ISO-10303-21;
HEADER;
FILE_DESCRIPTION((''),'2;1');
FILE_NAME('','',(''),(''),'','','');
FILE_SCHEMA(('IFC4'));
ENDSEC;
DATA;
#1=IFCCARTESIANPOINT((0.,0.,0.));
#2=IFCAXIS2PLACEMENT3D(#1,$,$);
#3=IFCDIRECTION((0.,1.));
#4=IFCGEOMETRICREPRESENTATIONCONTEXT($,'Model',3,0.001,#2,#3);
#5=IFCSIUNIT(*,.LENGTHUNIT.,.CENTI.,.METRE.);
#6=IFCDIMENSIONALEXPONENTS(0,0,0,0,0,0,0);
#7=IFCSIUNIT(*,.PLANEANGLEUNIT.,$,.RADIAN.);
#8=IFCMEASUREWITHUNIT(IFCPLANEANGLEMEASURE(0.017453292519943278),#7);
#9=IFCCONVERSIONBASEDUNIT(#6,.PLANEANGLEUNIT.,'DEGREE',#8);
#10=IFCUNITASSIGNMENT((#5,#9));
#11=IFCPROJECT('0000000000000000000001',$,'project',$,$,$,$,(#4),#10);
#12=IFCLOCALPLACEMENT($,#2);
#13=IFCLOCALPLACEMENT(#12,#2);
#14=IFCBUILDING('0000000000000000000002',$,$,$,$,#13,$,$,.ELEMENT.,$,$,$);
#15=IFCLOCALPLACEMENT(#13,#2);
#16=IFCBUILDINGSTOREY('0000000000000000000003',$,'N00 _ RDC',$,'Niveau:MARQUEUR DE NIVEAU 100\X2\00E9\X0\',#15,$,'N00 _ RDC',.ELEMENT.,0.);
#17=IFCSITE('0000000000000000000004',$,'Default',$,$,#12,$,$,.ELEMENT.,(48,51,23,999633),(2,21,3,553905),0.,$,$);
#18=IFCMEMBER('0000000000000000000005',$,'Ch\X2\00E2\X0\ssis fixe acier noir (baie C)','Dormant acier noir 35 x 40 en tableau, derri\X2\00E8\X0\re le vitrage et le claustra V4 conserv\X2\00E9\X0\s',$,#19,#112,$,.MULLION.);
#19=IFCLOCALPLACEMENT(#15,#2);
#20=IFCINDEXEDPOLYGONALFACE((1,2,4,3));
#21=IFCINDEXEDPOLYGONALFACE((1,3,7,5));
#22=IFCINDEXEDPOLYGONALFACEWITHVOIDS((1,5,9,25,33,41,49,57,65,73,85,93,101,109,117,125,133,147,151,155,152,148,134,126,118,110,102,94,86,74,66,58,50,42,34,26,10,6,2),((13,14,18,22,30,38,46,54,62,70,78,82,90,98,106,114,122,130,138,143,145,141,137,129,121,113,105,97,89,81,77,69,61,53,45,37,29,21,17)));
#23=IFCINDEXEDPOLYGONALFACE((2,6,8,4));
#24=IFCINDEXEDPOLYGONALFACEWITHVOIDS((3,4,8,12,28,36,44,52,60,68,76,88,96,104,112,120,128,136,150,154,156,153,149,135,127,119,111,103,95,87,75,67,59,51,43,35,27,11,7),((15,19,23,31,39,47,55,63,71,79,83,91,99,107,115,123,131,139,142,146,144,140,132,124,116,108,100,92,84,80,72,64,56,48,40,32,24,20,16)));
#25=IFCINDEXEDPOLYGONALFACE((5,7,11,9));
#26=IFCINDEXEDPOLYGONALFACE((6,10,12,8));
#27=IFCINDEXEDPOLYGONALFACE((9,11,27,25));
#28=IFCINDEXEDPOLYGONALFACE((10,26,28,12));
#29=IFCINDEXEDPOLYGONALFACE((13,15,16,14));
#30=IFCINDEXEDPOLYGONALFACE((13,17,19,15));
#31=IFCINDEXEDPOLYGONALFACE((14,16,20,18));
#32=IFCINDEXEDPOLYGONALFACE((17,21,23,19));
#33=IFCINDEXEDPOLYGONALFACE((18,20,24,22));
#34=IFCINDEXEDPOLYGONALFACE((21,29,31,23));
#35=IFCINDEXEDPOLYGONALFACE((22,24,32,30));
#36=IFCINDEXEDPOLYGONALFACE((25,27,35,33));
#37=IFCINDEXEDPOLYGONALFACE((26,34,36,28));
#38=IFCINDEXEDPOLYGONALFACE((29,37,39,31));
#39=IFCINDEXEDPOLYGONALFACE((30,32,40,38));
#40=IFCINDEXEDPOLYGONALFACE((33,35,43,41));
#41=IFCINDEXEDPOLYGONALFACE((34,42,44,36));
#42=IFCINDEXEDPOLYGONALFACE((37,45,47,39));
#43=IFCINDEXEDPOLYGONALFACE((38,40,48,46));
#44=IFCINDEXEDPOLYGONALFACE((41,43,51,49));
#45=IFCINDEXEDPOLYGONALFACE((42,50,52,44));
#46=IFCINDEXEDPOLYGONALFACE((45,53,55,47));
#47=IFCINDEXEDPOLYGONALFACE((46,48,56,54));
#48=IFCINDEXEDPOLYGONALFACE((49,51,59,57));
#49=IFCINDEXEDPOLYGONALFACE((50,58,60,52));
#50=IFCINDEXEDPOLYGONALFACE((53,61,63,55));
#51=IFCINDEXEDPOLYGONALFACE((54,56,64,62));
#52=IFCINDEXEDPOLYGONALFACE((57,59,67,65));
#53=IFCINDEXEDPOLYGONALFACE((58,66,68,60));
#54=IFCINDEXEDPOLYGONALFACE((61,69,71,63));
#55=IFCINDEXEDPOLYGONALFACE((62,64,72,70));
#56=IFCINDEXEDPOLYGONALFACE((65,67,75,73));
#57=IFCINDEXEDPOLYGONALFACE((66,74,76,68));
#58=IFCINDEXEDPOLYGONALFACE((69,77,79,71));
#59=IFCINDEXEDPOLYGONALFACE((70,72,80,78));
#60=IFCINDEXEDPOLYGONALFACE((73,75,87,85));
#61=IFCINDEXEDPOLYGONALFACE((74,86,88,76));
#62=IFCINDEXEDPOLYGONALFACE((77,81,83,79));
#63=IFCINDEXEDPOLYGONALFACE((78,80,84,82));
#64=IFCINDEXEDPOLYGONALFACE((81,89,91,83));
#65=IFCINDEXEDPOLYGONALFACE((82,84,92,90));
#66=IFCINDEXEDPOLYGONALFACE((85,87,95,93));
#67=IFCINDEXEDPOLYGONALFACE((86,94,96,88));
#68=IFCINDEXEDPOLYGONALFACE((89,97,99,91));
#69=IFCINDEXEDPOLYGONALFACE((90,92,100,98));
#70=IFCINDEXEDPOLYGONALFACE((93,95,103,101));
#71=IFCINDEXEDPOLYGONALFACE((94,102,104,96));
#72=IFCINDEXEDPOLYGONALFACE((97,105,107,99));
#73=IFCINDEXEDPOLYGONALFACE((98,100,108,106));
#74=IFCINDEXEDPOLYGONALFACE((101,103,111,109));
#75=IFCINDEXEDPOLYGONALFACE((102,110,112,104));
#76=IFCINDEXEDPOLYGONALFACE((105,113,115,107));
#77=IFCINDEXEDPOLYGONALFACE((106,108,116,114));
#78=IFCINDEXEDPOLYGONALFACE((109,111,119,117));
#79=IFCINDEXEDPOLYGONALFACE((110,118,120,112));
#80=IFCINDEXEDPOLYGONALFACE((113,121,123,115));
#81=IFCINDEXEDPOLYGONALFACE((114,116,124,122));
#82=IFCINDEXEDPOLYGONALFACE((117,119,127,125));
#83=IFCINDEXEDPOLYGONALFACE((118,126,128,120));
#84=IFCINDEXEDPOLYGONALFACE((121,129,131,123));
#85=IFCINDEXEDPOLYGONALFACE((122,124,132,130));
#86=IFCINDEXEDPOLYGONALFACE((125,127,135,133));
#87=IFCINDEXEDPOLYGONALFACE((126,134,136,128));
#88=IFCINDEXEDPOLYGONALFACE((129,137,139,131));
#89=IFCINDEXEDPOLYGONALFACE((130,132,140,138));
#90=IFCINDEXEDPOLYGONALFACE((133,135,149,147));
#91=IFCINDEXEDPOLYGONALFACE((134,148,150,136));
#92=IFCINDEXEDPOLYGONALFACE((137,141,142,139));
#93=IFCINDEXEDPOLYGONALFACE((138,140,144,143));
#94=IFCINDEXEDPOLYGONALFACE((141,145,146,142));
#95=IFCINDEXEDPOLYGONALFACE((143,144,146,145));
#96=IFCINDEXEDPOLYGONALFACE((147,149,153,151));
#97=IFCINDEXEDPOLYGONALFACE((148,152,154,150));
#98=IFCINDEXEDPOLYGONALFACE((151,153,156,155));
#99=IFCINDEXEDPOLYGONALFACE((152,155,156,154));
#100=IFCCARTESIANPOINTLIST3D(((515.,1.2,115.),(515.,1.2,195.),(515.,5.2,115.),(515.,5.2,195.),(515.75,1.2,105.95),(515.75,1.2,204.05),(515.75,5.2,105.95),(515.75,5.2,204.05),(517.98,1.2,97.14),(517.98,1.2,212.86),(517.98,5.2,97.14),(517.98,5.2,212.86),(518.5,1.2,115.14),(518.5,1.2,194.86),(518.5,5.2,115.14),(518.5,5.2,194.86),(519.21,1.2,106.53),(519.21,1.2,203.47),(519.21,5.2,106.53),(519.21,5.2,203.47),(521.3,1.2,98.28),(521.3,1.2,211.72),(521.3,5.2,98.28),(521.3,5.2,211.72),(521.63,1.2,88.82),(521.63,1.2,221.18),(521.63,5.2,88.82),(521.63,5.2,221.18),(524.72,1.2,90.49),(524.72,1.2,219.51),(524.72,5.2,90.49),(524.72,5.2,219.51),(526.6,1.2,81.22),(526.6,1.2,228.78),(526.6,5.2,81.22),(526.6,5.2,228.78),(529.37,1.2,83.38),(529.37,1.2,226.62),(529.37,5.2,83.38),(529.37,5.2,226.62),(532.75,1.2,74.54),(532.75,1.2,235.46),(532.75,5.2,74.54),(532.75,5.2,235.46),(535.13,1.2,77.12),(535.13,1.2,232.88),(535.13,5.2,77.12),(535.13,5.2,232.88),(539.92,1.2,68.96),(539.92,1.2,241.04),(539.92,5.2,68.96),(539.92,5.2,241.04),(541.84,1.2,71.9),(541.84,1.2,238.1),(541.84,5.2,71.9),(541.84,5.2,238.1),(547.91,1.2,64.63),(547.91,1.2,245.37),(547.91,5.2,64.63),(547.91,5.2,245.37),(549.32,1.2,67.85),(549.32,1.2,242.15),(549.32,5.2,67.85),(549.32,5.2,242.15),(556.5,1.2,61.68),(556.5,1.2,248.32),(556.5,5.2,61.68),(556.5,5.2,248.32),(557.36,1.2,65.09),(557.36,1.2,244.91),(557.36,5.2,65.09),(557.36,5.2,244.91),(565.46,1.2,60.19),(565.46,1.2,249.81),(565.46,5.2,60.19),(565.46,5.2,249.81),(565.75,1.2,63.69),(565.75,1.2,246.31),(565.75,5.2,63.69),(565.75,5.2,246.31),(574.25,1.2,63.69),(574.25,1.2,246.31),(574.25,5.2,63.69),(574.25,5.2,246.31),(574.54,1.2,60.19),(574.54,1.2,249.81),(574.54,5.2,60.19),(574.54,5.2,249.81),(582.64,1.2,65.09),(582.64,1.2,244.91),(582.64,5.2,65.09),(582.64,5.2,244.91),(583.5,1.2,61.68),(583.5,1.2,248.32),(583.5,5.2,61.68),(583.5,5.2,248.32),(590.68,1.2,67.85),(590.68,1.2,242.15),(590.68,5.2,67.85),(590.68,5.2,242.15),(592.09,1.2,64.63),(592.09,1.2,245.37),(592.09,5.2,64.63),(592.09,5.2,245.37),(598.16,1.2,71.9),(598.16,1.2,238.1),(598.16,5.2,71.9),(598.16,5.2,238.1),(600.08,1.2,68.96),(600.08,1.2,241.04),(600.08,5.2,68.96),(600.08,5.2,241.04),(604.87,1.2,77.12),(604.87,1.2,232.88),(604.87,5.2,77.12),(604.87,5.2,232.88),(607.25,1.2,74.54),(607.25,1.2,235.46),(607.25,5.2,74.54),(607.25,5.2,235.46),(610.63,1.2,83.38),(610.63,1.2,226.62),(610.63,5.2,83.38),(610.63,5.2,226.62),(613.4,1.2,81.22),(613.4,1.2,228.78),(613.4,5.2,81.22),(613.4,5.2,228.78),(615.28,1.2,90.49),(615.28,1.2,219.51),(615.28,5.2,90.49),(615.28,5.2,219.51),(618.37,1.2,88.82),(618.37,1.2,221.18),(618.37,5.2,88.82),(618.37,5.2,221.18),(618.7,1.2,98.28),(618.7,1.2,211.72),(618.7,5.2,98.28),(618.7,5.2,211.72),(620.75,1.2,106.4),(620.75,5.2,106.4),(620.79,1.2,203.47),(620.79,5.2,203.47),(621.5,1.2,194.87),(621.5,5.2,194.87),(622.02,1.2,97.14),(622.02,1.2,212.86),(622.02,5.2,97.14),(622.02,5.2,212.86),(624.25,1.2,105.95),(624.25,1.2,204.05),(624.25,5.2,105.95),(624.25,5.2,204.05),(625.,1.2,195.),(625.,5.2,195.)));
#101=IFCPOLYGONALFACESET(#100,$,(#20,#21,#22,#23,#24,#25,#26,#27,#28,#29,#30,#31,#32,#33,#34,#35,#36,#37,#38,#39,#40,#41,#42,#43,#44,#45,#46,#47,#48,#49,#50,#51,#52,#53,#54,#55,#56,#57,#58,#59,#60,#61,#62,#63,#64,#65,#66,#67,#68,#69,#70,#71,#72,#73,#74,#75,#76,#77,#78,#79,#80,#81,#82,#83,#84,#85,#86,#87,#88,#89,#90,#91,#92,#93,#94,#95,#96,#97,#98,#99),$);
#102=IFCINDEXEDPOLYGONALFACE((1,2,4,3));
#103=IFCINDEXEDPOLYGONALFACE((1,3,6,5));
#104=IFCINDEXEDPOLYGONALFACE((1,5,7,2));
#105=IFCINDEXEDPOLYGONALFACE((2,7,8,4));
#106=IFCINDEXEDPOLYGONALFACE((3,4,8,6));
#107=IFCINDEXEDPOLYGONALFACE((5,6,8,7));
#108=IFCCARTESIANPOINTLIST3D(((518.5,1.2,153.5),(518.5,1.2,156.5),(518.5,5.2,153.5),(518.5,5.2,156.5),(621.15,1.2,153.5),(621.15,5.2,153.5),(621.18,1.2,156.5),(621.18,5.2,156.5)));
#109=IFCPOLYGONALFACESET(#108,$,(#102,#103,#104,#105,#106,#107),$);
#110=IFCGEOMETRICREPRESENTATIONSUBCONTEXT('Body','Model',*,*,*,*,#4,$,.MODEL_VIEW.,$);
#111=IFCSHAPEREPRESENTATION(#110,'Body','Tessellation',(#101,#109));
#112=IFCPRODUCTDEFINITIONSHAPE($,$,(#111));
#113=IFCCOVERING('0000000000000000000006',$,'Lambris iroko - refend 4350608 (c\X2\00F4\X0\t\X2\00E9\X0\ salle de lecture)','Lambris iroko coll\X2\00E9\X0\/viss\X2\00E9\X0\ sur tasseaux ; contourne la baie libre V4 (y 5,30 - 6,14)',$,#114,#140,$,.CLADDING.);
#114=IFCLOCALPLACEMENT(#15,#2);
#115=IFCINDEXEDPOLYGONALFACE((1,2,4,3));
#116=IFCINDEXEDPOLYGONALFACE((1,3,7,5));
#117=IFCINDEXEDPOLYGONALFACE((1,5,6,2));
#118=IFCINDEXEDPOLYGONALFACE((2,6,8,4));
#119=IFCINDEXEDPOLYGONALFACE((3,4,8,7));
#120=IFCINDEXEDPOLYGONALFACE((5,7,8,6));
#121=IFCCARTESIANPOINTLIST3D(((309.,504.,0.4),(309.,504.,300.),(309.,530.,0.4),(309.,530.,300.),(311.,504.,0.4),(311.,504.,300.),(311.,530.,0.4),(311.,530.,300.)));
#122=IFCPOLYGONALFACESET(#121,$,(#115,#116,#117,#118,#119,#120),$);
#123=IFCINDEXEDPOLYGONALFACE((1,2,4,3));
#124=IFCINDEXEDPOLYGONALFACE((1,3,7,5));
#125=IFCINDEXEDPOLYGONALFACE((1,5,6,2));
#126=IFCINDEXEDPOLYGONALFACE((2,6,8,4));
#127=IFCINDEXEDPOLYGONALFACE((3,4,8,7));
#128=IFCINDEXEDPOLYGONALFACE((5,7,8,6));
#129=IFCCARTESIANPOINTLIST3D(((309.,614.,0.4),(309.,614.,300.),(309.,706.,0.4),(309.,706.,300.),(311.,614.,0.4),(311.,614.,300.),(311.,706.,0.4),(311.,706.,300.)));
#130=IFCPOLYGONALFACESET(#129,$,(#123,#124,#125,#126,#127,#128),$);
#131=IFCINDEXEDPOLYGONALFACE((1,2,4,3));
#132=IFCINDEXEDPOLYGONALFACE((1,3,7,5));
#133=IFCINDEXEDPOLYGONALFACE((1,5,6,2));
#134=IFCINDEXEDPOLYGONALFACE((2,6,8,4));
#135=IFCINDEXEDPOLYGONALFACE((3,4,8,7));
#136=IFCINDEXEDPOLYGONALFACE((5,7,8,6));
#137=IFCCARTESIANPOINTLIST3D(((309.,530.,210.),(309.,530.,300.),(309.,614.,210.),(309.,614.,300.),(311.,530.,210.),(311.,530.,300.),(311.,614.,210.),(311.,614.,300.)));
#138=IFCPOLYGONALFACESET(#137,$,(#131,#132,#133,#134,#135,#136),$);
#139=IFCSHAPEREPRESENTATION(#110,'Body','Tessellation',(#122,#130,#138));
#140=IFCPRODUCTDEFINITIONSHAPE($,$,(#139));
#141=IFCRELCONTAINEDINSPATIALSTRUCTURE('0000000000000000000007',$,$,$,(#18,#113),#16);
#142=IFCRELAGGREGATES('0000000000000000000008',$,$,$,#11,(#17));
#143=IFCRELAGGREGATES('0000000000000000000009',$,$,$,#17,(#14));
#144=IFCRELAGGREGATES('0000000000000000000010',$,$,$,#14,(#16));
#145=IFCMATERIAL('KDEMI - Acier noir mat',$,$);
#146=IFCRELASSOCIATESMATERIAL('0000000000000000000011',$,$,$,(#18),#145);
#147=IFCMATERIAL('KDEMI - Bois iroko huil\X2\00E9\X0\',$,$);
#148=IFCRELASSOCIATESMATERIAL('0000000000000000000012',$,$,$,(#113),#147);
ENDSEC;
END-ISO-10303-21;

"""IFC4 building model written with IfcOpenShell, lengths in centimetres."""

from ifc_helpers import new_model, entity, si_unit, converted_unit, direction, frame, frame_2d, origin, origin_with_axes, place, context, subcontext, project, spatial, polyline, rectangle, outline, extrude, material, element, save


model = new_model("IFC4")

# Units and contexts
model_context = context("Model", 3, precision=0.001, world=origin(), true_north=direction((0.0, 1.0)))
body_context = subcontext(model_context, "Body", "Model", "MODEL_VIEW")
ifc_project = project(units=[si_unit("LENGTHUNIT", "METRE", prefix="CENTI"), converted_unit("PLANEANGLEUNIT", "DEGREE", entity("IfcPlaneAngleMeasure", 0.017453292519943278), si_unit("PLANEANGLEUNIT", "RADIAN"), dimensions=[0, 0, 0, 0, 0, 0, 0])], contexts=[model_context])

# Site, building, storey
site_placement = place(None, origin())
site = spatial("IfcSite", under=ifc_project, at=site_placement, Name="Default", CompositionType="ELEMENT", RefLatitude=(48, 51, 23, 999633), RefLongitude=(2, 21, 3, 553905), RefElevation=0.0)
building_placement = place(site_placement, origin())
building = spatial("IfcBuilding", under=site, at=building_placement, CompositionType="ELEMENT")
storey_placement = place(building_placement, origin())
storey = spatial("IfcBuildingStorey", under=building, at=storey_placement, Name="N00 _ RDC", ObjectType="Niveau:MARQUEUR DE NIVEAU 100é", LongName="N00 _ RDC", CompositionType="ELEMENT", Elevation=0.0)

# Member
ifc_material_1 = material(Name="KDEMI - Acier noir mat")
member_1_placement = place(storey_placement, origin_with_axes())
element("IfcMember", 1, at=member_1_placement, inside=storey, material=ifc_material_1, Name="Châssis fixe acier noir (baie C)", Description="Dormant acier noir 35 x 40 en tableau, derrière le vitrage et le claustra V4 conservés", PredefinedType="MULLION", context=body_context, shape_type="SweptSolid", body=[
    extrude(outline(polyline([(624.25, 105.95), (622.02, 97.14), (618.37, 88.82), (613.4, 81.22), (607.25, 74.54), (600.08, 68.96), (592.09, 64.63), (583.5, 61.68), (574.54, 60.19), (565.46, 60.19), (556.5, 61.68), (547.91, 64.63), (539.92, 68.96), (532.75, 74.54), (526.6, 81.22), (521.63, 88.82), (517.98, 97.14), (515.75, 105.95), (515.0, 115.0), (515.0, 195.0), (515.75, 204.05), (517.98, 212.86), (521.63, 221.18), (526.6, 228.78), (532.75, 235.46), (539.92, 241.04), (547.91, 245.37), (556.5, 248.32), (565.46, 249.81), (574.54, 249.81), (583.5, 248.32), (592.09, 245.37), (600.08, 241.04), (607.25, 235.46), (613.4, 228.78), (618.37, 221.18), (622.02, 212.86), (624.25, 204.05), (625.0, 195.0), (624.25, 105.95)]), holes=[polyline([(620.79, 203.47), (618.7, 211.72), (615.28, 219.51), (610.63, 226.62), (604.87, 232.88), (598.16, 238.1), (590.68, 242.15), (582.64, 244.91), (574.25, 246.31), (565.75, 246.31), (557.36, 244.91), (549.32, 242.15), (541.84, 238.1), (535.13, 232.88), (529.37, 226.62), (524.72, 219.51), (521.3, 211.72), (519.21, 203.47), (518.5, 194.86), (518.5, 115.14), (519.21, 106.53), (521.3, 98.28), (524.72, 90.49), (529.37, 83.38), (535.13, 77.12), (541.84, 71.9), (549.32, 67.85), (557.36, 65.09), (565.75, 63.69), (574.25, 63.69), (582.64, 65.09), (590.68, 67.85), (598.16, 71.9), (604.87, 77.12), (610.63, 83.38), (615.28, 90.49), (618.7, 98.28), (620.75, 106.4), (621.5, 194.87), (620.79, 203.47)])]), frame((0.0, 5.2, 0.0), z_axis=(0.0, -1.0, 0.0), x_axis=(1.0, 0.0, 0.0)), (0.0, 0.0, 1.0), 4.0),
    extrude(outline(polyline([(621.18, 156.5), (621.15, 153.5), (518.5, 153.5), (518.5, 156.5), (621.18, 156.5)])), frame((0.0, 5.2, 0.0), z_axis=(0.0, -1.0, 0.0), x_axis=(1.0, 0.0, 0.0)), (0.0, 0.0, 1.0), 4.0),
])

# Covering
ifc_material_2 = material(Name="KDEMI - Bois iroko huilé")
covering_placement = place(storey_placement, origin_with_axes())
element("IfcCovering", 2, at=covering_placement, inside=storey, material=ifc_material_2, Name="Lambris iroko - refend 4350608 (côté salle de lecture)", Description="Lambris iroko collé/vissé sur tasseaux ; contourne la baie libre V4 (y 5,30 - 6,14)", PredefinedType="CLADDING", context=body_context, shape_type="SweptSolid", body=[
    extrude(rectangle(XDim=2.0, YDim=26.0, at=frame_2d((310.0, 517.0))), frame((0.0, 0.0, 0.4)), (0.0, 0.0, 1.0), 299.6),
    extrude(rectangle(XDim=2.0, YDim=92.0, at=frame_2d((310.0, 660.0))), frame((0.0, 0.0, 0.4)), (0.0, 0.0, 1.0), 299.6),
    extrude(rectangle(XDim=2.0, YDim=84.0, at=frame_2d((310.0, 572.0))), frame((0.0, 0.0, 210.0)), (0.0, 0.0, 1.0), 90.0),
])

save(model, "model.ifc")
